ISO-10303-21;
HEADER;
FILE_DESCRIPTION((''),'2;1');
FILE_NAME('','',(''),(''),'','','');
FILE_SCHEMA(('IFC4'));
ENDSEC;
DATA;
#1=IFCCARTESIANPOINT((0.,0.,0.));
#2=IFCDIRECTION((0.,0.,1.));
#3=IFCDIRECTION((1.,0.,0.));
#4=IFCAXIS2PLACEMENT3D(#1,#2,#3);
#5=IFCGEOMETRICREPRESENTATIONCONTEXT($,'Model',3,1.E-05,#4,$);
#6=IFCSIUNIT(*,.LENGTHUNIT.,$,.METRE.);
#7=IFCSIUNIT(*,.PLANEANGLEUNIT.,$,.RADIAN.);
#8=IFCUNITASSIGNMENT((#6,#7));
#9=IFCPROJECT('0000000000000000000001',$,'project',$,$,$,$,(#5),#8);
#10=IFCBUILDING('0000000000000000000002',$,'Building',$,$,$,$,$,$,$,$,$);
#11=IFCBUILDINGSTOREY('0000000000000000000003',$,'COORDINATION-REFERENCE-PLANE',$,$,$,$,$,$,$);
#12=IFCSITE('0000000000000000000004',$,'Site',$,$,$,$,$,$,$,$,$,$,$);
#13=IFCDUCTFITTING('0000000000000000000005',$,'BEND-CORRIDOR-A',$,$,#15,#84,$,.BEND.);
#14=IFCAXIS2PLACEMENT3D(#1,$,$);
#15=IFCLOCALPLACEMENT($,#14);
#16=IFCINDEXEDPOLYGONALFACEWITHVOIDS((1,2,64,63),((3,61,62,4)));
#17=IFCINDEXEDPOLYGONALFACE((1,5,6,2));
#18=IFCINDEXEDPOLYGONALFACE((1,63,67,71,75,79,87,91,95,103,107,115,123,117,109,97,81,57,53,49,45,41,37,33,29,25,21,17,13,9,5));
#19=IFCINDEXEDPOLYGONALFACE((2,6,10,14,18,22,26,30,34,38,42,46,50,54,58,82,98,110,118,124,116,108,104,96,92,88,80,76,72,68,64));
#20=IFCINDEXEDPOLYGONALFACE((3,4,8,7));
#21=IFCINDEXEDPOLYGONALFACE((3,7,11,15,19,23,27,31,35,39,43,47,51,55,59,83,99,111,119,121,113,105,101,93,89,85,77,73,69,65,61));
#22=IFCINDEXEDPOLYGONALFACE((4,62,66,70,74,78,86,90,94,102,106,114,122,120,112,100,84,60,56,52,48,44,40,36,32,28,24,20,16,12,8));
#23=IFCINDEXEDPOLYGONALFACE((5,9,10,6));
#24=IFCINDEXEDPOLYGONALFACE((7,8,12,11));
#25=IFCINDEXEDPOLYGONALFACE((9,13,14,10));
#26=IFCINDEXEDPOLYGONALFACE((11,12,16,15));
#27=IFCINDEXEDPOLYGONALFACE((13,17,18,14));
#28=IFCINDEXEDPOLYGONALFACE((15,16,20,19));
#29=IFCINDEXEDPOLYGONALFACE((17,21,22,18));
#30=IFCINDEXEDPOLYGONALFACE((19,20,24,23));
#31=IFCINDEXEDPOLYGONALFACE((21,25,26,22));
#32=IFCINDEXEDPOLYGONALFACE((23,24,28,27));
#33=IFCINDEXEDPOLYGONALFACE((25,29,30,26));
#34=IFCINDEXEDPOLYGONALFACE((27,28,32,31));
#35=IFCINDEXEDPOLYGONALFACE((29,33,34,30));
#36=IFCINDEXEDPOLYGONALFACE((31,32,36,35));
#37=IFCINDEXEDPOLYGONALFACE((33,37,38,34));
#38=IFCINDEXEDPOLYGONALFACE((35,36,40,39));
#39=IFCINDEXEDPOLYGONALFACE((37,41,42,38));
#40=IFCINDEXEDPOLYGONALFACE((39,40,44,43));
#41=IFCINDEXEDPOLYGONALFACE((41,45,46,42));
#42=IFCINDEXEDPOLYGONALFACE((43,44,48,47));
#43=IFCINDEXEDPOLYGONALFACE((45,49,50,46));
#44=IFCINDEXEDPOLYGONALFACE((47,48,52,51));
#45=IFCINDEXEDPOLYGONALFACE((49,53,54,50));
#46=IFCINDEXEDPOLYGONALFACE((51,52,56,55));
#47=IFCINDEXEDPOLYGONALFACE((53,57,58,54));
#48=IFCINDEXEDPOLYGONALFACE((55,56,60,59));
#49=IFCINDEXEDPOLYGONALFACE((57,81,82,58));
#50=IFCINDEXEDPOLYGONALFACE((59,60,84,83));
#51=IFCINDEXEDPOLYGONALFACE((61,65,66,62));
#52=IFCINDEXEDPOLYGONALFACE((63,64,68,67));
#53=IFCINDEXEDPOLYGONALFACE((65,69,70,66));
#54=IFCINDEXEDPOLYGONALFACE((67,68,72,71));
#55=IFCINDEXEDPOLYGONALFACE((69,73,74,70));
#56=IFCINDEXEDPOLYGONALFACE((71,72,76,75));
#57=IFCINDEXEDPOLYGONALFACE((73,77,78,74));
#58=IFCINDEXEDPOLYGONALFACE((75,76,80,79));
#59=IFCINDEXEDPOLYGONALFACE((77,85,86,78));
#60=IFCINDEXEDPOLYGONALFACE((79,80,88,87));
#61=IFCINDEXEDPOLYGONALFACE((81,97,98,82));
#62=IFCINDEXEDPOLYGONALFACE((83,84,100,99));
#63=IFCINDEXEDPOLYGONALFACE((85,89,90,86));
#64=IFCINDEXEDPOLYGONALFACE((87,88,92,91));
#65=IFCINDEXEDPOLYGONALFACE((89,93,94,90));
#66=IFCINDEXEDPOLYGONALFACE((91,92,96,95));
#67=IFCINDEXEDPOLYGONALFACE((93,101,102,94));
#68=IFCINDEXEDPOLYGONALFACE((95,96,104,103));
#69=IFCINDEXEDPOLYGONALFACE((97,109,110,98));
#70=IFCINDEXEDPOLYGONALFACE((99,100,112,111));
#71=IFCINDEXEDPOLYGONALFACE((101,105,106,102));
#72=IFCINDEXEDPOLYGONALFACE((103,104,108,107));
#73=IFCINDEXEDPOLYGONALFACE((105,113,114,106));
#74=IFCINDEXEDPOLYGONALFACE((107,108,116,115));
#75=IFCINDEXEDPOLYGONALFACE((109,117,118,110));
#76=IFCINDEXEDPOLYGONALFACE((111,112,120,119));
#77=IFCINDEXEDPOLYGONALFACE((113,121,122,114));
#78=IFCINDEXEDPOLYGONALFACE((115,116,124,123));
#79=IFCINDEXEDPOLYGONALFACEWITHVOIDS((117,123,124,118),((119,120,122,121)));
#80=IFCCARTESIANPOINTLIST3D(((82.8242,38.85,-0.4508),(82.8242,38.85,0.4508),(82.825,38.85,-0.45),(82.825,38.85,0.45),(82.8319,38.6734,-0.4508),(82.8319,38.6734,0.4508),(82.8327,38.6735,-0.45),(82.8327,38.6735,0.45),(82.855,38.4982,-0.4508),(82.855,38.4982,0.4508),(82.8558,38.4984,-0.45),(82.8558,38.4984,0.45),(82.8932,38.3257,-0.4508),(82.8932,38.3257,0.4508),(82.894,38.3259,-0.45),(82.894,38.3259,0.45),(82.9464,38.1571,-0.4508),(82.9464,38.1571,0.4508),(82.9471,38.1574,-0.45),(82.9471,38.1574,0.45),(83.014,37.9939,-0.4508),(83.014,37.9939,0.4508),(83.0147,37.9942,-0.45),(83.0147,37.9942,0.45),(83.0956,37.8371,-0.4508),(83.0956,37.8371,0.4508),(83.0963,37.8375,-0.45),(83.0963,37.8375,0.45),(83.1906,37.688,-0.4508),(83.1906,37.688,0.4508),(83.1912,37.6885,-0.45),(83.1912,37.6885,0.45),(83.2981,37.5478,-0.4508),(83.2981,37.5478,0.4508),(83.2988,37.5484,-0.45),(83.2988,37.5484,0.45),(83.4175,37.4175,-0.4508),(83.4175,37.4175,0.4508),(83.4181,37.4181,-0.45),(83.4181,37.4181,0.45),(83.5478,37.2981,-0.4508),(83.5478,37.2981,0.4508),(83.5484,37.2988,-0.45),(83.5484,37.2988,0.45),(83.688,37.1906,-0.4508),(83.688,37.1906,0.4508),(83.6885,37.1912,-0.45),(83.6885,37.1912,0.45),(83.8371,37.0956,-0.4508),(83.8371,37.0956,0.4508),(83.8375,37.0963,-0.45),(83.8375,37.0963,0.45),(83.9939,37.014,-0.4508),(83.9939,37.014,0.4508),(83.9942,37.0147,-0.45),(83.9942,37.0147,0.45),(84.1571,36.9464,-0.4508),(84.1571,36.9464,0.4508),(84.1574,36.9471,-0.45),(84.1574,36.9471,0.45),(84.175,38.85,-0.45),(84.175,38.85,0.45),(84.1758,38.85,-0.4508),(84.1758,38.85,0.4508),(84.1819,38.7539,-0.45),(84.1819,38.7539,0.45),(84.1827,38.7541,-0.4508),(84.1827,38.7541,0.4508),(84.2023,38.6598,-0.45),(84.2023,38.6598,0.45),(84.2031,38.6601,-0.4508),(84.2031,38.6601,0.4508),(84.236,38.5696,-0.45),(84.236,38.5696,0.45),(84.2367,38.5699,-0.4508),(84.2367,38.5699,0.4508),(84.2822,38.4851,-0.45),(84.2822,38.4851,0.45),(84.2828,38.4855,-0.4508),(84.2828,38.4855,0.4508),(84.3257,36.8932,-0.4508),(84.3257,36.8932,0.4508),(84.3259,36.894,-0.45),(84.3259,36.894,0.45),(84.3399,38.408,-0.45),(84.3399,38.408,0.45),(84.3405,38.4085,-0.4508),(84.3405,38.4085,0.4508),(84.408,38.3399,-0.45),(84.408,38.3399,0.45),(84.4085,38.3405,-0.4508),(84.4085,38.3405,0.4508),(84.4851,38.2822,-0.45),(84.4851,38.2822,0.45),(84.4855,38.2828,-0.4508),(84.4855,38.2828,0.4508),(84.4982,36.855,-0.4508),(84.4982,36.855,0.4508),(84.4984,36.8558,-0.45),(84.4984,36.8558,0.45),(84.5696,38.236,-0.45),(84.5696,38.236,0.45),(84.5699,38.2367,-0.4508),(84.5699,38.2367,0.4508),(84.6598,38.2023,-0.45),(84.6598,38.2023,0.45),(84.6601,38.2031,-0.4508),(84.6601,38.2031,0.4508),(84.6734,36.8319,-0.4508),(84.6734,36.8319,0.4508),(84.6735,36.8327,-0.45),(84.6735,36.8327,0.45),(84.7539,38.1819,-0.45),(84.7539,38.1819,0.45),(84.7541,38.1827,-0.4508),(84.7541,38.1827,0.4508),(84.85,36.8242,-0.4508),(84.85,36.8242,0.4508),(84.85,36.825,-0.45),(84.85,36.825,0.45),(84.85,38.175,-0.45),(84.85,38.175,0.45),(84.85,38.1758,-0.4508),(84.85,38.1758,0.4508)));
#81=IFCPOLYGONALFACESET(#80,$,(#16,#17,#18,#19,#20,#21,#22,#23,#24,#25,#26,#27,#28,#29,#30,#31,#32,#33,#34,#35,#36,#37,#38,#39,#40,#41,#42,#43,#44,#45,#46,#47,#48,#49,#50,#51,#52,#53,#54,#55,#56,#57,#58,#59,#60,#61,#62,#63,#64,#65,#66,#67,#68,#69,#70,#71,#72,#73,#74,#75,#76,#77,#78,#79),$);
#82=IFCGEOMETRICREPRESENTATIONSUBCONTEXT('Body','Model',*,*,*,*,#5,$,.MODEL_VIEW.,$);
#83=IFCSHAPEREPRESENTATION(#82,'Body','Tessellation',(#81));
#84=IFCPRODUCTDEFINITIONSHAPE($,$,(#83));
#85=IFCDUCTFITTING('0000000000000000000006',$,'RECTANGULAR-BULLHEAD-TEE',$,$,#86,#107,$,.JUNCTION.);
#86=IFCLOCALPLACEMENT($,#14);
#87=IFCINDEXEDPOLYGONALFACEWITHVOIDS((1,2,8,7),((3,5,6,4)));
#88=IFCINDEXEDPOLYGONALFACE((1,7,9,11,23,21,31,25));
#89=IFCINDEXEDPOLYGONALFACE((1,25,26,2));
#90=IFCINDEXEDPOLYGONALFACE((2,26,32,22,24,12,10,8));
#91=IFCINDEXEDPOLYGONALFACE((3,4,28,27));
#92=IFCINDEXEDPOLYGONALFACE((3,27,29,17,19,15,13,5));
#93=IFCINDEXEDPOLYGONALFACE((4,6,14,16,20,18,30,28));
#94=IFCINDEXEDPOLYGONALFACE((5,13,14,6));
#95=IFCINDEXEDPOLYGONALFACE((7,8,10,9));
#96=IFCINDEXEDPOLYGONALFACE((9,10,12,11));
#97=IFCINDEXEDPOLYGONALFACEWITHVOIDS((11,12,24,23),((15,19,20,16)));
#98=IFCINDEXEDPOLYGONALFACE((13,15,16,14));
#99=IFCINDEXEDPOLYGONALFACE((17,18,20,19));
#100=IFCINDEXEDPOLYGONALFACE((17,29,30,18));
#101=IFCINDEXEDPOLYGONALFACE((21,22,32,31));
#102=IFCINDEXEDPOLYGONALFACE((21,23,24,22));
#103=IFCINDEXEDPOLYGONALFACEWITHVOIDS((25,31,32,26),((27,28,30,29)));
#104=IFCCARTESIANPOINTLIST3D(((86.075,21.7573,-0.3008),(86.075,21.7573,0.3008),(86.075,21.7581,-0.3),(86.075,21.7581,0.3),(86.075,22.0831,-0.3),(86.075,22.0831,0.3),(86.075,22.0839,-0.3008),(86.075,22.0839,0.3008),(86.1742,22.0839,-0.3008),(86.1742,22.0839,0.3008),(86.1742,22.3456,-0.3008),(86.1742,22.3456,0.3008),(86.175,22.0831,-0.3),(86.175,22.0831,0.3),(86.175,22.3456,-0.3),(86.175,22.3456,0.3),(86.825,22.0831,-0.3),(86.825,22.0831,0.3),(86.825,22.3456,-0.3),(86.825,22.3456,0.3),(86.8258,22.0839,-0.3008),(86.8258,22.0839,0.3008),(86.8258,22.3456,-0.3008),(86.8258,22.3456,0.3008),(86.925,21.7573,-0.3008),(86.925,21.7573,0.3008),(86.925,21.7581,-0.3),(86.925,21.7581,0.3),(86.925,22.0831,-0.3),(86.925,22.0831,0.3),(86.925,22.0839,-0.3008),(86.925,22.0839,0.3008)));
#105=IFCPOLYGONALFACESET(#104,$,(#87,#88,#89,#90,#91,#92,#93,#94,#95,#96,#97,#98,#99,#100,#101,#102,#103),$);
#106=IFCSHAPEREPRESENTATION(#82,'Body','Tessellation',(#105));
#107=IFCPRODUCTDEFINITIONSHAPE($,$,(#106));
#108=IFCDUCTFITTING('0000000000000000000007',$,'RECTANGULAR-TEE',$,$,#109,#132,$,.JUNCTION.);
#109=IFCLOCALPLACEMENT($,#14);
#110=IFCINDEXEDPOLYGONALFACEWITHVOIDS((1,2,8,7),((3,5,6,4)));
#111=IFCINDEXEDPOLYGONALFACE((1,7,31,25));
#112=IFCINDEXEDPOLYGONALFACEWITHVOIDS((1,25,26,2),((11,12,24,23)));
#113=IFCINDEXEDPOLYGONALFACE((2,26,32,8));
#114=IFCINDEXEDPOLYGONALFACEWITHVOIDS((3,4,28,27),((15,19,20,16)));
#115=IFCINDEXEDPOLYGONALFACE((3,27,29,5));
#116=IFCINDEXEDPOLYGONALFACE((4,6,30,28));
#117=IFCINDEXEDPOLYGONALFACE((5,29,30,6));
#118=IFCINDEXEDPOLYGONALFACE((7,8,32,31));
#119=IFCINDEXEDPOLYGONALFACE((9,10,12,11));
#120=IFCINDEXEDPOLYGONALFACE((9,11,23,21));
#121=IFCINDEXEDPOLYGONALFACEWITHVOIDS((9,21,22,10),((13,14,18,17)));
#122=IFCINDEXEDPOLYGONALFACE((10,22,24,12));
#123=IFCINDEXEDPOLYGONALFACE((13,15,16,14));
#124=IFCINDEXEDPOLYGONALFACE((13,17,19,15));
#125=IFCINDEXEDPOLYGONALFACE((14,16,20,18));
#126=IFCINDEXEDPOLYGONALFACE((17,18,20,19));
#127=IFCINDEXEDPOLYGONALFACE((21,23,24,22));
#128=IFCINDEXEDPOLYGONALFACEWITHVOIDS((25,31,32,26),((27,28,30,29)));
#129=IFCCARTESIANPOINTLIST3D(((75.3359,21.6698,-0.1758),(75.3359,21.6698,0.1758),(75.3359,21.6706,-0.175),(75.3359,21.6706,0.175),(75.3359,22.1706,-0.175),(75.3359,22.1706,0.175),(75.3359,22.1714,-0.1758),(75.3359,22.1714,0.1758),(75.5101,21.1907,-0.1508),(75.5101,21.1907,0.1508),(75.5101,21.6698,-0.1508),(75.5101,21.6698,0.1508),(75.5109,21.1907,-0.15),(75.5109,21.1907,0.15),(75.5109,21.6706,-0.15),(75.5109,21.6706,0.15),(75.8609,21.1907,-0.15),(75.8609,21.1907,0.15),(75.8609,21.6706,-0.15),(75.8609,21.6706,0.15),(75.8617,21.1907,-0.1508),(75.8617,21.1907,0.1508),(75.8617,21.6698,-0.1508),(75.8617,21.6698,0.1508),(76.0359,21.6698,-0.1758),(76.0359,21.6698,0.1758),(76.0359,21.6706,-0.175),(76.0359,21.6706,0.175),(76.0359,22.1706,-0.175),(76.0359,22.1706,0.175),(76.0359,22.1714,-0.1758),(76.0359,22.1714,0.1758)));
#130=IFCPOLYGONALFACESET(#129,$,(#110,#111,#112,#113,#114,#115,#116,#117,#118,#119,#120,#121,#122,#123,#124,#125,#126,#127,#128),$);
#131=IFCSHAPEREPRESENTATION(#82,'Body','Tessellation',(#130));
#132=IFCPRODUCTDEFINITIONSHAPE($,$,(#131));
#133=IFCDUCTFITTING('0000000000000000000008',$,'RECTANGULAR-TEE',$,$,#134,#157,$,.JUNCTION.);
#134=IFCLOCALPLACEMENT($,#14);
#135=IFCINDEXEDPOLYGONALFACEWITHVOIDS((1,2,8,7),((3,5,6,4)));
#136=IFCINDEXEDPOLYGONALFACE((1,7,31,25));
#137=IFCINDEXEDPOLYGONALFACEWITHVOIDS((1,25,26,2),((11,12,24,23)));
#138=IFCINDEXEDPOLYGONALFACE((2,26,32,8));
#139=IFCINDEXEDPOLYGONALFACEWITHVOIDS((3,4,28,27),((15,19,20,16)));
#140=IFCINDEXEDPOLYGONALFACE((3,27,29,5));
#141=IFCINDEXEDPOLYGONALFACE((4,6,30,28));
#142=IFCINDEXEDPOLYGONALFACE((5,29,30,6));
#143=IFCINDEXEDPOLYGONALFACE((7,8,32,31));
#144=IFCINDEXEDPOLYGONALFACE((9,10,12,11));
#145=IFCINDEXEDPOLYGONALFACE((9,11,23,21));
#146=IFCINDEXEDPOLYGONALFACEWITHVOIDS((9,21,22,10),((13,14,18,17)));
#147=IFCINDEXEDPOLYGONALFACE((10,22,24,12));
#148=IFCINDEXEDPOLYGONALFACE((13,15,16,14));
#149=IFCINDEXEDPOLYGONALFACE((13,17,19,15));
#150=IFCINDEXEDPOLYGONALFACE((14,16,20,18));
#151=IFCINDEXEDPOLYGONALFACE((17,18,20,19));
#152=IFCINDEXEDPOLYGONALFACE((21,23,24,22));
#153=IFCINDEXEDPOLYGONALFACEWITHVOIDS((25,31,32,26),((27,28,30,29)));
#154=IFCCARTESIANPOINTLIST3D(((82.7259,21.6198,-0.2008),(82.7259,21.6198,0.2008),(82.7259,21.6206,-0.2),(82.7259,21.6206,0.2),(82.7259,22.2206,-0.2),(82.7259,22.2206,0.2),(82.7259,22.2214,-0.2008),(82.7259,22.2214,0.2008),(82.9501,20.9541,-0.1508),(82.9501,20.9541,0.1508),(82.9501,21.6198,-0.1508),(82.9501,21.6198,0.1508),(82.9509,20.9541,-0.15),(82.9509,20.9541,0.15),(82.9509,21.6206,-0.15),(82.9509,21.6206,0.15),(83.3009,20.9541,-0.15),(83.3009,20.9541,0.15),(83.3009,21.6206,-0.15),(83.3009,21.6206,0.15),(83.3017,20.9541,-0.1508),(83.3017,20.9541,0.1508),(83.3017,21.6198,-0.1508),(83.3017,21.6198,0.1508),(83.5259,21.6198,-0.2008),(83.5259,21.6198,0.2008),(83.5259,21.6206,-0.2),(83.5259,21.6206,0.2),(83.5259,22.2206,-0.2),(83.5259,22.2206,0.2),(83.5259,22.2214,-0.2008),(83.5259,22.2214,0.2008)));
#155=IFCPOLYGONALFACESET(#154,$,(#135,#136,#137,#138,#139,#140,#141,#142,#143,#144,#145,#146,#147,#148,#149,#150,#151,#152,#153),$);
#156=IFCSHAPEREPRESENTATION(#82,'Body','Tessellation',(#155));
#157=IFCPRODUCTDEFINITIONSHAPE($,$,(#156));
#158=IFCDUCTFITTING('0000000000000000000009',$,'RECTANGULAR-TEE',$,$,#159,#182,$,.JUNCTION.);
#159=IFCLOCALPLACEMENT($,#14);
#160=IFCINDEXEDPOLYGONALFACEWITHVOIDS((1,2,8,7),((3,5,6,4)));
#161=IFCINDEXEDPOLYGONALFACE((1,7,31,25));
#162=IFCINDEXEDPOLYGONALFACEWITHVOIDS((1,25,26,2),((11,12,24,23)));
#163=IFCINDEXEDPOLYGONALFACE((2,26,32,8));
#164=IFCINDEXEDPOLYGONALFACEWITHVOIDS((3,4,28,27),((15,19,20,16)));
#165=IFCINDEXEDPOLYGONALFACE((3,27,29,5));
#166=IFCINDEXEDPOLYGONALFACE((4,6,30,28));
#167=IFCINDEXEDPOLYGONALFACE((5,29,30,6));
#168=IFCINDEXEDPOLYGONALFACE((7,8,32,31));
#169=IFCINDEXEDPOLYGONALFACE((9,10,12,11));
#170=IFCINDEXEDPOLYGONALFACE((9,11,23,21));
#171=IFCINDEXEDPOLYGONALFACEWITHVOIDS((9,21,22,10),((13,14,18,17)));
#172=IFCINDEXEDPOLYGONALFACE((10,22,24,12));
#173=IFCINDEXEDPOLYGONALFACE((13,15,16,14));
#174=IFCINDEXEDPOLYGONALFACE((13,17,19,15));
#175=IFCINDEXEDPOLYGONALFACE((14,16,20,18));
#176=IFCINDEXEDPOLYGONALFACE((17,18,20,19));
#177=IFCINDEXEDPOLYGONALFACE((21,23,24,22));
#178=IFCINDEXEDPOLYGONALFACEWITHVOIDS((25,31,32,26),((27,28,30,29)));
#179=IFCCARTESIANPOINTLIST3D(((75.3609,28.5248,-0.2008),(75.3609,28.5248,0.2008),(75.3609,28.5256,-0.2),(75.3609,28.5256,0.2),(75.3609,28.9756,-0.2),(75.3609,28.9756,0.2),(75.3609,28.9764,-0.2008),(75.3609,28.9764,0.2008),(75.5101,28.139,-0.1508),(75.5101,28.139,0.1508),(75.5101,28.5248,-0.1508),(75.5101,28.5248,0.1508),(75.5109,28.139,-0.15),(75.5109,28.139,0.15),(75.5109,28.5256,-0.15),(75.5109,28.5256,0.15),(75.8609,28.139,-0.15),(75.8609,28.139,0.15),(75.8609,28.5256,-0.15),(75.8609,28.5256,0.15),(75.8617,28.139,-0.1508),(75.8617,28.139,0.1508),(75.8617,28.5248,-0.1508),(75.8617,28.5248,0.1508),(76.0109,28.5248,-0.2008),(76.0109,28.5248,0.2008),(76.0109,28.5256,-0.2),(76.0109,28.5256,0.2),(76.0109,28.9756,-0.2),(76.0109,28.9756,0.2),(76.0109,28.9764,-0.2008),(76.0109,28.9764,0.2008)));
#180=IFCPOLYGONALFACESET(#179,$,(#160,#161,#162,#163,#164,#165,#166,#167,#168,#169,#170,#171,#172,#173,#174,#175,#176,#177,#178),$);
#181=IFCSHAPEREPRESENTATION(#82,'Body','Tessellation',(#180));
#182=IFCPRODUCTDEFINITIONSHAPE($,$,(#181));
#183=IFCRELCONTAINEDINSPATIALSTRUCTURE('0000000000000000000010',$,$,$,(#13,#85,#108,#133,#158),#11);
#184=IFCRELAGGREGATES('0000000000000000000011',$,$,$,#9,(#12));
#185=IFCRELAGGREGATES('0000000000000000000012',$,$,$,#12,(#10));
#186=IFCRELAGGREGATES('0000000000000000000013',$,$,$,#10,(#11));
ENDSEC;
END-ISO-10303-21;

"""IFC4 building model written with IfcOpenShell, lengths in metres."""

from ifc_helpers import new_model, entity, si_unit, frame, origin_with_axes, place, context, subcontext, project, spatial, rectangle, extrude, boolean, element, save


model = new_model("IFC4")

# Units and contexts
model_context = context("Model", 3, precision=1e-05, world=origin_with_axes())
body_context = subcontext(model_context, "Body", "Model", "MODEL_VIEW")
ifc_project = project(units=[si_unit("LENGTHUNIT", "METRE"), si_unit("PLANEANGLEUNIT", "RADIAN")], contexts=[model_context])

# Site, building, storey
site = spatial("IfcSite", under=ifc_project, Name="Site")
building = spatial("IfcBuilding", under=site, Name="Building")
storey = spatial("IfcBuildingStorey", under=building, Name="COORDINATION-REFERENCE-PLANE")

# Duct fittings
duct_fitting_1_placement = place(None, frame((84.85, 38.85, 0.0), z_axis=(0.0, 0.0, 1.0), x_axis=(-1.0, 0.0, 0.0)))
cartesian_point_1 = entity("IfcCartesianPoint", [0.0, 0.0, 0.0])
element("IfcDuctFitting", 1, at=duct_fitting_1_placement, inside=storey, Name="BEND-CORRIDOR-A", PredefinedType="BEND", context=body_context, shape_type="SweptSolid", body=[
    entity("IfcRevolvedAreaSolid", entity("IfcRectangleHollowProfileDef", "AREA", None, entity("IfcAxis2Placement2D", entity("IfcCartesianPoint", [1.35, 0.0])), 1.3516, 0.9016, 0.0008), entity("IfcAxis2Placement3D", cartesian_point_1, entity("IfcDirection", [0.0, -1.0, 0.0]), entity("IfcDirection", [1.0, 0.0, 0.0])), entity("IfcAxis1Placement", cartesian_point_1, entity("IfcDirection", [0.0, 1.0, 0.0])), 1.570796),
])
duct_fitting_2_placement = place(None, frame((86.5, 21.9206, 0.0), z_axis=(1.0, 0.0, 0.0), x_axis=(0.0, 1.0, 0.0)))
solid_1 = boolean("UNION", extrude(rectangle(XDim=0.325, YDim=0.6), frame((0.0, 0.0, -0.425), z_axis=(0.0, 0.0, 1.0), x_axis=(1.0, 0.0, 0.0)), (0.0, 0.0, 1.0), 0.85), extrude(rectangle(XDim=0.65, YDim=0.6), frame((0.0, 0.0, 0.0), z_axis=(1.0, 0.0, 0.0), x_axis=(0.0, 0.0, -1.0)), (0.0, 0.0, 1.0), 0.425))
element("IfcDuctFitting", 2, at=duct_fitting_2_placement, inside=storey, Name="RECTANGULAR-BULLHEAD-TEE", PredefinedType="JUNCTION", context=body_context, shape_type="CSG", body=[
    boolean("DIFFERENCE", boolean("UNION", extrude(rectangle(XDim=0.3266, YDim=0.6016), frame((0.0, 0.0, -0.425), z_axis=(0.0, 0.0, 1.0), x_axis=(1.0, 0.0, 0.0)), (0.0, 0.0, 1.0), 0.85), extrude(rectangle(XDim=0.6516, YDim=0.6016), frame((0.0, 0.0, 0.0), z_axis=(1.0, 0.0, 0.0), x_axis=(0.0, 0.0, -1.0)), (0.0, 0.0, 1.0), 0.425)), solid_1),
])
duct_fitting_3_placement = place(None, frame((75.6859, 21.9206, 0.0), z_axis=(-1.0, 0.0, 0.0), x_axis=(0.0, -1.0, 0.0)))
solid_2 = boolean("UNION", extrude(rectangle(XDim=0.5, YDim=0.35), frame((0.0, 0.0, -0.35), z_axis=(0.0, 0.0, 1.0), x_axis=(1.0, 0.0, 0.0)), (0.0, 0.0, 1.0), 0.7), extrude(rectangle(XDim=0.35, YDim=0.3), frame((0.0, 0.0, 0.0), z_axis=(1.0, 0.0, 0.0), x_axis=(0.0, 0.0, -1.0)), (0.0, 0.0, 1.0), 0.7299))
element("IfcDuctFitting", 3, at=duct_fitting_3_placement, inside=storey, Name="RECTANGULAR-TEE", PredefinedType="JUNCTION", context=body_context, shape_type="CSG", body=[
    boolean("DIFFERENCE", boolean("UNION", extrude(rectangle(XDim=0.5016, YDim=0.3516), frame((0.0, 0.0, -0.35), z_axis=(0.0, 0.0, 1.0), x_axis=(1.0, 0.0, 0.0)), (0.0, 0.0, 1.0), 0.7), extrude(rectangle(XDim=0.3516, YDim=0.3016), frame((0.0, 0.0, 0.0), z_axis=(1.0, 0.0, 0.0), x_axis=(0.0, 0.0, -1.0)), (0.0, 0.0, 1.0), 0.7299)), solid_2),
])
duct_fitting_4_placement = place(None, frame((83.1259, 21.9206, 0.0), z_axis=(-1.0, 0.0, 0.0), x_axis=(0.0, -1.0, 0.0)))
solid_3 = boolean("UNION", extrude(rectangle(XDim=0.6, YDim=0.4), frame((0.0, 0.0, -0.4), z_axis=(0.0, 0.0, 1.0), x_axis=(1.0, 0.0, 0.0)), (0.0, 0.0, 1.0), 0.8), extrude(rectangle(XDim=0.35, YDim=0.3), frame((0.0, 0.0, 0.0), z_axis=(1.0, 0.0, 0.0), x_axis=(0.0, 0.0, -1.0)), (0.0, 0.0, 1.0), 0.9665))
element("IfcDuctFitting", 4, at=duct_fitting_4_placement, inside=storey, Name="RECTANGULAR-TEE", PredefinedType="JUNCTION", context=body_context, shape_type="CSG", body=[
    boolean("DIFFERENCE", boolean("UNION", extrude(rectangle(XDim=0.6016, YDim=0.4016), frame((0.0, 0.0, -0.4), z_axis=(0.0, 0.0, 1.0), x_axis=(1.0, 0.0, 0.0)), (0.0, 0.0, 1.0), 0.8), extrude(rectangle(XDim=0.3516, YDim=0.3016), frame((0.0, 0.0, 0.0), z_axis=(1.0, 0.0, 0.0), x_axis=(0.0, 0.0, -1.0)), (0.0, 0.0, 1.0), 0.9665)), solid_3),
])
duct_fitting_5_placement = place(None, frame((75.6859, 28.7506, 0.0), z_axis=(-1.0, 0.0, 0.0), x_axis=(0.0, -1.0, 0.0)))
solid_4 = boolean("UNION", extrude(rectangle(XDim=0.45, YDim=0.4), frame((0.0, 0.0, -0.325), z_axis=(0.0, 0.0, 1.0), x_axis=(1.0, 0.0, 0.0)), (0.0, 0.0, 1.0), 0.65), extrude(rectangle(XDim=0.35, YDim=0.3), frame((0.0, 0.0, 0.0), z_axis=(1.0, 0.0, 0.0), x_axis=(0.0, 0.0, -1.0)), (0.0, 0.0, 1.0), 0.6116))
element("IfcDuctFitting", 5, at=duct_fitting_5_placement, inside=storey, Name="RECTANGULAR-TEE", PredefinedType="JUNCTION", context=body_context, shape_type="CSG", body=[
    boolean("DIFFERENCE", boolean("UNION", extrude(rectangle(XDim=0.4516, YDim=0.4016), frame((0.0, 0.0, -0.325), z_axis=(0.0, 0.0, 1.0), x_axis=(1.0, 0.0, 0.0)), (0.0, 0.0, 1.0), 0.65), extrude(rectangle(XDim=0.3516, YDim=0.3016), frame((0.0, 0.0, 0.0), z_axis=(1.0, 0.0, 0.0), x_axis=(0.0, 0.0, -1.0)), (0.0, 0.0, 1.0), 0.6116)), solid_4),
])

save(model, "model.ifc")
